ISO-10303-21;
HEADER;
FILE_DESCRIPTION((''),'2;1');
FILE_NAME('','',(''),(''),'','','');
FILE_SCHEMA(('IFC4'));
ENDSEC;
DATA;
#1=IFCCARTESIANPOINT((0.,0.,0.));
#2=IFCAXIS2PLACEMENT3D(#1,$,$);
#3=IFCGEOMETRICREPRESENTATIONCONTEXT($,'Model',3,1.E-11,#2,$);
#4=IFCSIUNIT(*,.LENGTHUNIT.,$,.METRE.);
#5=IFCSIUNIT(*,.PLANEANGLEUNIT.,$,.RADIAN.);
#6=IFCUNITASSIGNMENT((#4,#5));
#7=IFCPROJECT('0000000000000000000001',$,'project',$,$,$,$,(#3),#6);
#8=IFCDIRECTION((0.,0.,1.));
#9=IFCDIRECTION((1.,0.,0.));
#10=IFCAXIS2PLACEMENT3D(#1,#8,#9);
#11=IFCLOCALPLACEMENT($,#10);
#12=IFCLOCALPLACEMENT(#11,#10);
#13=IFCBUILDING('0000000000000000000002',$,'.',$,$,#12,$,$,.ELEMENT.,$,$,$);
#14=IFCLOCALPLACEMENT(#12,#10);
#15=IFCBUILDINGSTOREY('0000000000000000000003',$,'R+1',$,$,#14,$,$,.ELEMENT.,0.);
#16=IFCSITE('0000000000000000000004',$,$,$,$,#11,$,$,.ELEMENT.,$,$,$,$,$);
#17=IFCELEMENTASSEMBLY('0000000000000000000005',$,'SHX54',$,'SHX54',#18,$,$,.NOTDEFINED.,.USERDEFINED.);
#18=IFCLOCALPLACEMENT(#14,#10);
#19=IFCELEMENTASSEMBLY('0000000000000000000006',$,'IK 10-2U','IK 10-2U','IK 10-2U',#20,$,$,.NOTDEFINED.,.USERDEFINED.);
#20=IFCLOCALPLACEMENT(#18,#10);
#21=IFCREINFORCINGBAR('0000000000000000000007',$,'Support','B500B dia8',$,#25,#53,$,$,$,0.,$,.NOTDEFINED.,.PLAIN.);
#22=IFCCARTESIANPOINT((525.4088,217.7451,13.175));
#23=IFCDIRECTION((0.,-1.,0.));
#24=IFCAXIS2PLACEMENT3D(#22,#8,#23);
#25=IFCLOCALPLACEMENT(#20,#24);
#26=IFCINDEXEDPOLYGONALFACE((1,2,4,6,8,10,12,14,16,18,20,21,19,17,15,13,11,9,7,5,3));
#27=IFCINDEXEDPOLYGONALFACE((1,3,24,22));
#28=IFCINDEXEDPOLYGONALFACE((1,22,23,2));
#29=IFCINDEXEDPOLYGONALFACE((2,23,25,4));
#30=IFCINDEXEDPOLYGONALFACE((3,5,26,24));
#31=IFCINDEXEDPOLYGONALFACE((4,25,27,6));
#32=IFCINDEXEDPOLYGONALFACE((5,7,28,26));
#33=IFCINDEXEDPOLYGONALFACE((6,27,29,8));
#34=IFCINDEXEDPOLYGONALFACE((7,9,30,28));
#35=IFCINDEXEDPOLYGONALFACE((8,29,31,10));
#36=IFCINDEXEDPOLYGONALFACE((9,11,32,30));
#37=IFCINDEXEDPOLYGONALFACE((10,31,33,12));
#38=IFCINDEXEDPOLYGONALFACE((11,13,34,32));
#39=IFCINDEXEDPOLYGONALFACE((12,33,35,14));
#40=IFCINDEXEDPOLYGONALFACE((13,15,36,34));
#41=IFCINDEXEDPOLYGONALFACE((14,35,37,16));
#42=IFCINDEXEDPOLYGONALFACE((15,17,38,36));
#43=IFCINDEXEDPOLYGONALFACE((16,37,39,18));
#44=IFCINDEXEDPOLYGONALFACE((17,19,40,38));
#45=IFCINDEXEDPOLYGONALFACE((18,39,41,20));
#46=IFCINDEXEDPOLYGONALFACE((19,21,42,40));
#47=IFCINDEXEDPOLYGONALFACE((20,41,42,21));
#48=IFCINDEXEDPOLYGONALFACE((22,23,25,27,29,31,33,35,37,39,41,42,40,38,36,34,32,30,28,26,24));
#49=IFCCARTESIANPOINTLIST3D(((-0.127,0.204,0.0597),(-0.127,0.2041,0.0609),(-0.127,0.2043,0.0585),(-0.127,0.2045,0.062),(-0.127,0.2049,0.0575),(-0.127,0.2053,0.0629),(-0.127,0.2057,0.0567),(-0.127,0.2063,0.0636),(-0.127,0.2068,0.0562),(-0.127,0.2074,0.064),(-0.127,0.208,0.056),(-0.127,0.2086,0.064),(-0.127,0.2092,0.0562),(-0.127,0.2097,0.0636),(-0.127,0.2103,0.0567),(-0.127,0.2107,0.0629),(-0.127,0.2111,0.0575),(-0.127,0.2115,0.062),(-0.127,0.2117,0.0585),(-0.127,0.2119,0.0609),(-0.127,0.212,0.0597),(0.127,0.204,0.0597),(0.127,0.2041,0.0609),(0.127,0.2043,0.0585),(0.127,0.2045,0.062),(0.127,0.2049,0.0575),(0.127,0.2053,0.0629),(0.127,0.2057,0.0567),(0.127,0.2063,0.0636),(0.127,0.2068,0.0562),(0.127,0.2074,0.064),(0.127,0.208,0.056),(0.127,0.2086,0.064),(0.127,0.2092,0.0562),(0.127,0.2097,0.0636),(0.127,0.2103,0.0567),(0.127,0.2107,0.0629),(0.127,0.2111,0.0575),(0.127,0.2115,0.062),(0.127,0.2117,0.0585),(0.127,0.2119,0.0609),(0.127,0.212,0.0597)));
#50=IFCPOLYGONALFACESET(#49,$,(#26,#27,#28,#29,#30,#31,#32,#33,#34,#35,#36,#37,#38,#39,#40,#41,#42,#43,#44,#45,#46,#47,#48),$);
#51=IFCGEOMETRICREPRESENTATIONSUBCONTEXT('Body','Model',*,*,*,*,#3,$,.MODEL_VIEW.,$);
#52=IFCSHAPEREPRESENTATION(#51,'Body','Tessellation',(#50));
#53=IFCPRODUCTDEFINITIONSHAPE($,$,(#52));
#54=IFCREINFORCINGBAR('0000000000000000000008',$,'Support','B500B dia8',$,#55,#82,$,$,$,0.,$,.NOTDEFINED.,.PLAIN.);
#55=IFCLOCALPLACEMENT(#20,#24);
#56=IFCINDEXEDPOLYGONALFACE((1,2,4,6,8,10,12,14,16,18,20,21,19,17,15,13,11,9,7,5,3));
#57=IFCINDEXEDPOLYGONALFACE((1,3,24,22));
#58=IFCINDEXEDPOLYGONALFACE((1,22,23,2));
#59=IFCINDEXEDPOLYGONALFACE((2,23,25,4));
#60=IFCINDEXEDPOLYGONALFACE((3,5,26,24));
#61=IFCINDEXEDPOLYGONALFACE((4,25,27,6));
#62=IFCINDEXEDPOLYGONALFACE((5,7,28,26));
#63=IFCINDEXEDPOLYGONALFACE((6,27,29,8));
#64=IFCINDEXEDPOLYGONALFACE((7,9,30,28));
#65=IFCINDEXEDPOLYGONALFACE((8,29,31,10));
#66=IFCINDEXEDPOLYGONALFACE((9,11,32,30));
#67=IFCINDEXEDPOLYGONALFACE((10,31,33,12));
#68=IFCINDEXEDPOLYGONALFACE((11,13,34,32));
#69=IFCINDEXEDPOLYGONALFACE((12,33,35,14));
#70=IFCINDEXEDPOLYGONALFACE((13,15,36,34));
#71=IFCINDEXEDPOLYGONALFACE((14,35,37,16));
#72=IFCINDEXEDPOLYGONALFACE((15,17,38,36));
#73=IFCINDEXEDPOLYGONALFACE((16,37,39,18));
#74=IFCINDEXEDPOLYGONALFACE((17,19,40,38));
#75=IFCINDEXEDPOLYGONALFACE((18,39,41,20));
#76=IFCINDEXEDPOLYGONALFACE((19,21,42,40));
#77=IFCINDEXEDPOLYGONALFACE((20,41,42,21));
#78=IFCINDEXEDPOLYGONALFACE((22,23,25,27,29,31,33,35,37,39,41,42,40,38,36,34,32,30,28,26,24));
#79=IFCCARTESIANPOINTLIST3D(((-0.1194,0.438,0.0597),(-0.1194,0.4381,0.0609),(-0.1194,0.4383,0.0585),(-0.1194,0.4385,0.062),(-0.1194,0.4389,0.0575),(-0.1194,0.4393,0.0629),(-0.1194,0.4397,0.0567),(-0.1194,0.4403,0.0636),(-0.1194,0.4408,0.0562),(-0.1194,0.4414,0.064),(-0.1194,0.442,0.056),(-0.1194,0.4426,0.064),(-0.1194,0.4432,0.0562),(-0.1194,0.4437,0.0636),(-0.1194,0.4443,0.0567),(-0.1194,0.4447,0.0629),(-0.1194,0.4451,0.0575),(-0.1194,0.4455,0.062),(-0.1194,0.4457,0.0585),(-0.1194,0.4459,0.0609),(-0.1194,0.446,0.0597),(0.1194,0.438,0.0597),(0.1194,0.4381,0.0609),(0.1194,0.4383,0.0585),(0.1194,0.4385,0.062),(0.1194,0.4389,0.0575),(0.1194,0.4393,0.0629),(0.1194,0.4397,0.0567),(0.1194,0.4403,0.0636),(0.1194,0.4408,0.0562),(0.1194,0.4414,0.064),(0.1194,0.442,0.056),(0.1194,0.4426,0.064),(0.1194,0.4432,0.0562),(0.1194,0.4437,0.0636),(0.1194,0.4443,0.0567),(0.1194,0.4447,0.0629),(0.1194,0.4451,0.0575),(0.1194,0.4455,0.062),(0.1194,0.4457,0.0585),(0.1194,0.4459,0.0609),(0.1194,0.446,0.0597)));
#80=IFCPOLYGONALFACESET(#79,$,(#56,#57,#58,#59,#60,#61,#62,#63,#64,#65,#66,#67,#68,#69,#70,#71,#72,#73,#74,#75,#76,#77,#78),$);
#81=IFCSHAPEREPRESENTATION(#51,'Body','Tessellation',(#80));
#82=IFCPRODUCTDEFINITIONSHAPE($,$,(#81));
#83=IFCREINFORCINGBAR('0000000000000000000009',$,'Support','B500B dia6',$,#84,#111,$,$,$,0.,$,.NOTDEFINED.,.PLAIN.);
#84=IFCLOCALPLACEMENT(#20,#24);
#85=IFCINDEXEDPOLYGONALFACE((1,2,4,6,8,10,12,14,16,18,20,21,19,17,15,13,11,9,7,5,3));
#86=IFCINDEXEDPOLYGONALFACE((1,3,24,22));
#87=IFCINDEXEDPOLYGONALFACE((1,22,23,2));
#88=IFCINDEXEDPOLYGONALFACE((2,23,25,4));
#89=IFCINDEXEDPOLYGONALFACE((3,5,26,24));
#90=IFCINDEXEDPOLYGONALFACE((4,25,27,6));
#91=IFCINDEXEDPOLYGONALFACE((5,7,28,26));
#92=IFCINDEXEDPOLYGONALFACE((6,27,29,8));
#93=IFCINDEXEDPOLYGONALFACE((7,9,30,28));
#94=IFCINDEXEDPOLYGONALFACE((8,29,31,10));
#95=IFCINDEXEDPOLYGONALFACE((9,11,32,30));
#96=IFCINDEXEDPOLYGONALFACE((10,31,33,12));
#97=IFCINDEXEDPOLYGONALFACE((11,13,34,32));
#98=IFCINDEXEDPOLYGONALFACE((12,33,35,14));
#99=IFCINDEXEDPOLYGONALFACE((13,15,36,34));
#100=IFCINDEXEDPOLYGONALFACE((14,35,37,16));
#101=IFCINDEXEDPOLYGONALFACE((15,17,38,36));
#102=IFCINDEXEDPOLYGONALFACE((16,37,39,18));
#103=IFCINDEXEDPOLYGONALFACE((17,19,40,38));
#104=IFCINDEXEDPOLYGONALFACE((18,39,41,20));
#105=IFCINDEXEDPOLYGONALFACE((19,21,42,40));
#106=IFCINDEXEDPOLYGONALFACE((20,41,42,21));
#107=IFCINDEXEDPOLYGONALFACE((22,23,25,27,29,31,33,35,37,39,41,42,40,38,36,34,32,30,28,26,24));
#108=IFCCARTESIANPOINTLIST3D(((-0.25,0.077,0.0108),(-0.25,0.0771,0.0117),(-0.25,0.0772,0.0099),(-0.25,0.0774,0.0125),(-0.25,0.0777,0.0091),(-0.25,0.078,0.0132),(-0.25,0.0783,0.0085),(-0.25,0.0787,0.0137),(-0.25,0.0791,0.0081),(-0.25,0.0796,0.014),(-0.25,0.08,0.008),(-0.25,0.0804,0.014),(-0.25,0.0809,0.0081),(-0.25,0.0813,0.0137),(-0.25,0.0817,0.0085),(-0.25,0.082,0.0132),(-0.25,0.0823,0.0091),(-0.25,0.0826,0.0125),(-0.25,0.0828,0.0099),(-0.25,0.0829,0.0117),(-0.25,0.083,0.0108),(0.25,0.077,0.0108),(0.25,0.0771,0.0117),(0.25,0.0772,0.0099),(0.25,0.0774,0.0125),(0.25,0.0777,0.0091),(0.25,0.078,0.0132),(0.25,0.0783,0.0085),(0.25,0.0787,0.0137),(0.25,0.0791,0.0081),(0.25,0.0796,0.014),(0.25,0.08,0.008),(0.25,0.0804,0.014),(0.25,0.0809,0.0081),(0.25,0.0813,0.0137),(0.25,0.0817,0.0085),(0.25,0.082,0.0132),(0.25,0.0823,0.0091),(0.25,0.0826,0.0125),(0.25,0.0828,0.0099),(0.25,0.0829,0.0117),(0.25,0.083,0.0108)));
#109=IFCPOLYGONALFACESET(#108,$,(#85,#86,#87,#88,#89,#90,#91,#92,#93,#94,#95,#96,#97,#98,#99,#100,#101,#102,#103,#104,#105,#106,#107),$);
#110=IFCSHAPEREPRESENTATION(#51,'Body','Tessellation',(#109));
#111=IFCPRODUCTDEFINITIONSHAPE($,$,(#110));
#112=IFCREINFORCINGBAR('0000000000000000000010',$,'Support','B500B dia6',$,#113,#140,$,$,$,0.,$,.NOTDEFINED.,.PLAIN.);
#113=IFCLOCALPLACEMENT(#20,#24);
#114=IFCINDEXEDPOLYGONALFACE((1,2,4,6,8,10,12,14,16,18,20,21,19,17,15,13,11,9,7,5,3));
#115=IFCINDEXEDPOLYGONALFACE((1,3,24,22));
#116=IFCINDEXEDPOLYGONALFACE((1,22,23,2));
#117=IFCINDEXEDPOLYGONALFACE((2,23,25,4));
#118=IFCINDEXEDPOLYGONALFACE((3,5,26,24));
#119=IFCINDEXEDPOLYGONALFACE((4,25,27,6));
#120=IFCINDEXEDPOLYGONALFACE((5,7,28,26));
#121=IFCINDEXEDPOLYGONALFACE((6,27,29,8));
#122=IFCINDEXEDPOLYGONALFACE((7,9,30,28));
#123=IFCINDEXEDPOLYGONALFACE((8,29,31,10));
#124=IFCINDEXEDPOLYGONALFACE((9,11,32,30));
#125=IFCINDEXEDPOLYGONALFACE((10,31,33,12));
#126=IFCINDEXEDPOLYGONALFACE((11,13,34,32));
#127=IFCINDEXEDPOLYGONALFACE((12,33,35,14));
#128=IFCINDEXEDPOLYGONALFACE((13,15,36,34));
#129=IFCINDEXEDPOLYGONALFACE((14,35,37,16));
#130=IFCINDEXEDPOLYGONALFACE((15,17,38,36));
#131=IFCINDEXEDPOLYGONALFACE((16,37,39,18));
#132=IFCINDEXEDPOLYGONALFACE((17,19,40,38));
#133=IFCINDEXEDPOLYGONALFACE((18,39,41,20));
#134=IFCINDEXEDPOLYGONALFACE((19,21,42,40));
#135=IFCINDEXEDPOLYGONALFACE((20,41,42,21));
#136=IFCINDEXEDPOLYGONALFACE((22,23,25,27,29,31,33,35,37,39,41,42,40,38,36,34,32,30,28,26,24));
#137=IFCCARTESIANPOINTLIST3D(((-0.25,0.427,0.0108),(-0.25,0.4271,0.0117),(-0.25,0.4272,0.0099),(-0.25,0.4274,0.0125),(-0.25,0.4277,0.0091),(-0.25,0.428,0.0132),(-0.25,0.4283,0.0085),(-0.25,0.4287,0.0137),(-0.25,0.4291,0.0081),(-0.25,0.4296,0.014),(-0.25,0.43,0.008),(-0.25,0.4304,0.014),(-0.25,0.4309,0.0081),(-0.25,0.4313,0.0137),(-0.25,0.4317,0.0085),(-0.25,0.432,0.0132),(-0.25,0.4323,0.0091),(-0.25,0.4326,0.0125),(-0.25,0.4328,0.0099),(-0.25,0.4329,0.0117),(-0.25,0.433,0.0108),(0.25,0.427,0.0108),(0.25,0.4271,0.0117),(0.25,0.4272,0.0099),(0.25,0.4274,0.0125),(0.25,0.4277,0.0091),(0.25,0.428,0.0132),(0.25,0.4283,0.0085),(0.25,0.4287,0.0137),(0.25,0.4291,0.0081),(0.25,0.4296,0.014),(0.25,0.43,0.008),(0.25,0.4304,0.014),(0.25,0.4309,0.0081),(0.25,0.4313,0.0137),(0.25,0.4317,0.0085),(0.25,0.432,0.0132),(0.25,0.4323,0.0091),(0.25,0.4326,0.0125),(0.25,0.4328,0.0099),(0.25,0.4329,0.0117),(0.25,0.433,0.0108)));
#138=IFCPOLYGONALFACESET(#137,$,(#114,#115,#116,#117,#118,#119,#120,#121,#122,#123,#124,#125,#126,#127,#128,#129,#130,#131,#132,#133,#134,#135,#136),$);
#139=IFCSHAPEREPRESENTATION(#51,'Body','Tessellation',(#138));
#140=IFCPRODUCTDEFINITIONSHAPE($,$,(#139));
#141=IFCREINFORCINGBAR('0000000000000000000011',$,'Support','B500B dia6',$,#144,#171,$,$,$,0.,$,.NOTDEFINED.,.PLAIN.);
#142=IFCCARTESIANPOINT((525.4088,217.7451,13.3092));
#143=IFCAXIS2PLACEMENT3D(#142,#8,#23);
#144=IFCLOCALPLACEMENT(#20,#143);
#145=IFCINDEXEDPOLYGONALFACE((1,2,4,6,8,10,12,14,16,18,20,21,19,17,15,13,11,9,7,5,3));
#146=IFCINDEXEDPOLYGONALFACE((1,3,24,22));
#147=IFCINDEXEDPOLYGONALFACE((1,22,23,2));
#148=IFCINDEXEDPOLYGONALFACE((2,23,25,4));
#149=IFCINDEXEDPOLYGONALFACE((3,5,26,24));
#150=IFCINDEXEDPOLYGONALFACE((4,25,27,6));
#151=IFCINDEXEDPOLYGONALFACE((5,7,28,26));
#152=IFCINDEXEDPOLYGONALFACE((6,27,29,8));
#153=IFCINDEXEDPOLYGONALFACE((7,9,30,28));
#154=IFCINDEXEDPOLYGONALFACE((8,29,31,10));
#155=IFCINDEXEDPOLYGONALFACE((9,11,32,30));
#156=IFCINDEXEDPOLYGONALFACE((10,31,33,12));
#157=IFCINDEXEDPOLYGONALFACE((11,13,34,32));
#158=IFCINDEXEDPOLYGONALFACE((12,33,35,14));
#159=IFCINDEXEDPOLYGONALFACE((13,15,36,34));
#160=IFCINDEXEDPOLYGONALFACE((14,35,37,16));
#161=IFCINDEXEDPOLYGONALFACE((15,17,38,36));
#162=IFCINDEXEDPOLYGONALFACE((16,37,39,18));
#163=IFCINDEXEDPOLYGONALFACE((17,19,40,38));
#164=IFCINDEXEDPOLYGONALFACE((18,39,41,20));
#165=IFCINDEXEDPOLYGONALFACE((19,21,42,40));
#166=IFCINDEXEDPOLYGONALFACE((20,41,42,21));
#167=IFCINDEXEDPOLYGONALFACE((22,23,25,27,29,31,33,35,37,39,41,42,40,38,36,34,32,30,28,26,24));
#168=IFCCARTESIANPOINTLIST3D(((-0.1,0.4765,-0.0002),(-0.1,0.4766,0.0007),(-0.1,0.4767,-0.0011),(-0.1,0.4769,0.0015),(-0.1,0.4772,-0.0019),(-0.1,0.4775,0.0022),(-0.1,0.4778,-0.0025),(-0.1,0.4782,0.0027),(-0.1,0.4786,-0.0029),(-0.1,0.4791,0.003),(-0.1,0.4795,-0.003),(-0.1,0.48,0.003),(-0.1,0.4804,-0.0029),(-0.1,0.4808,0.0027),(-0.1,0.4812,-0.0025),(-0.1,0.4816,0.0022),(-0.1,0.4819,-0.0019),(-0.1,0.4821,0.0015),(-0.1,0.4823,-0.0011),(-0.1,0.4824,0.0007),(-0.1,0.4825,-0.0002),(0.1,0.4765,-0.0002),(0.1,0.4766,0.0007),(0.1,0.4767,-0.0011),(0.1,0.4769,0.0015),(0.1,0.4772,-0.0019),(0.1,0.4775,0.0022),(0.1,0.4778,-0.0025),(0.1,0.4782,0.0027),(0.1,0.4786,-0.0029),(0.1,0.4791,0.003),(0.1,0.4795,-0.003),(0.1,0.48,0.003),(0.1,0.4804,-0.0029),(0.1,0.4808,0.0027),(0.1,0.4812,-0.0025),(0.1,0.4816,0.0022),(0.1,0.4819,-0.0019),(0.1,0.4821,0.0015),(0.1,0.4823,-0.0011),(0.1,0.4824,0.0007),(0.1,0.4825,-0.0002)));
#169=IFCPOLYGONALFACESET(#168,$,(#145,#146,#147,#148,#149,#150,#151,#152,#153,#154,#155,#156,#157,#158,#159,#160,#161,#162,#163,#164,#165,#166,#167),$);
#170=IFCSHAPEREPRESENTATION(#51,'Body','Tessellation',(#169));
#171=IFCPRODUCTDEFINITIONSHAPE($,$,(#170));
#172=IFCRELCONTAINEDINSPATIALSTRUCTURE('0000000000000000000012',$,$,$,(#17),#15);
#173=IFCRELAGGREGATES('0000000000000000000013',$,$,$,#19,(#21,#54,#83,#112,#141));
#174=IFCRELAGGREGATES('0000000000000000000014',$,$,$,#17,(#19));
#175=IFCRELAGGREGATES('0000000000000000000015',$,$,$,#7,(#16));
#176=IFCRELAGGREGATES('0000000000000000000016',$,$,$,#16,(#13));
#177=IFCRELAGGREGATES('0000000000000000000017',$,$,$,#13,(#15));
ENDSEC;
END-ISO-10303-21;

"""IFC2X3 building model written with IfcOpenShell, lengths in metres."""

from ifc_helpers import new_model, entity, si_unit, frame, origin, origin_with_axes, place, context, subcontext, project, spatial, source, transform, mapped, element, aggregate, save


model = new_model("IFC2X3")

# Units and contexts
model_context = context("Model", 3, precision=1e-11, world=origin())
body_context = subcontext(model_context, "Body", "Model", "MODEL_VIEW")
ifc_project = project(units=[si_unit("LENGTHUNIT", "METRE"), si_unit("PLANEANGLEUNIT", "RADIAN")], contexts=[model_context])

# Site, building, storey
site_placement = place(None, origin_with_axes())
site = spatial("IfcSite", under=ifc_project, at=site_placement, CompositionType="ELEMENT")
building_placement = place(site_placement, origin_with_axes())
building = spatial("IfcBuilding", under=site, at=building_placement, Name=".", CompositionType="ELEMENT")
storey_placement = place(building_placement, origin_with_axes())
storey = spatial("IfcBuildingStorey", under=building, at=storey_placement, Name="R+1", CompositionType="ELEMENT", Elevation=0.0)

# Element assemblies, reinforcing bars
assembly_1_placement = place(storey_placement, origin_with_axes())
assembly_1 = element("IfcElementAssembly", 1, at=assembly_1_placement, inside=storey, Name="SHX54", ObjectType="SHX54", AssemblyPlace="NOTDEFINED", PredefinedType="USERDEFINED")
assembly_2_placement = place(assembly_1_placement, origin_with_axes())
assembly_2 = element("IfcElementAssembly", 2, at=assembly_2_placement, Name="IK 10-2U", Description="IK 10-2U", ObjectType="IK 10-2U", AssemblyPlace="NOTDEFINED", PredefinedType="USERDEFINED")
shared_shape_1 = source(origin_with_axes(), body_context, "Body", "AdvancedSweptSolid", [
    entity("IfcSweptDiskSolid", entity("IfcPolyline", [entity("IfcCartesianPoint", [0.127, 0.208, 0.06]), entity("IfcCartesianPoint", [-0.127, 0.208, 0.06])]), 0.004, None, 0.0, 0.254),
])
reinforcing_bar_1_placement = place(assembly_2_placement, frame((525.4088, 217.7451, 13.175), z_axis=(0.0, 0.0, 1.0), x_axis=(0.0, -1.0, 0.0)))
reinforcing_bar_1 = element("IfcReinforcingBar", 3, at=reinforcing_bar_1_placement, Name="Support", Description="B500B dia8", BarRole="NOTDEFINED", BarSurface="PLAIN", CrossSectionArea=0.0, context=body_context, shape_type="MappedRepresentation", body=[
    mapped(shared_shape_1, transform((0.0, 0.0, 0.0), scale=1.0)),
])
shared_shape_2 = source(origin_with_axes(), body_context, "Body", "AdvancedSweptSolid", [
    entity("IfcSweptDiskSolid", entity("IfcPolyline", [entity("IfcCartesianPoint", [0.1194, 0.442, 0.06]), entity("IfcCartesianPoint", [-0.1194, 0.442, 0.06])]), 0.004, None, 0.0, 0.2388),
])
reinforcing_bar_2_placement = place(assembly_2_placement, frame((525.4088, 217.7451, 13.175), z_axis=(0.0, 0.0, 1.0), x_axis=(0.0, -1.0, 0.0)))
reinforcing_bar_2 = element("IfcReinforcingBar", 4, at=reinforcing_bar_2_placement, Name="Support", Description="B500B dia8", BarRole="NOTDEFINED", BarSurface="PLAIN", CrossSectionArea=0.0, context=body_context, shape_type="MappedRepresentation", body=[
    mapped(shared_shape_2, transform((0.0, 0.0, 0.0), scale=1.0)),
])
shared_shape_3 = source(origin_with_axes(), body_context, "Body", "AdvancedSweptSolid", [
    entity("IfcSweptDiskSolid", entity("IfcPolyline", [entity("IfcCartesianPoint", [0.25, 0.08, 0.011]), entity("IfcCartesianPoint", [-0.25, 0.08, 0.011])]), 0.003, None, 0.0, 0.5),
])
reinforcing_bar_3_placement = place(assembly_2_placement, frame((525.4088, 217.7451, 13.175), z_axis=(0.0, 0.0, 1.0), x_axis=(0.0, -1.0, 0.0)))
reinforcing_bar_3 = element("IfcReinforcingBar", 5, at=reinforcing_bar_3_placement, Name="Support", Description="B500B dia6", BarRole="NOTDEFINED", BarSurface="PLAIN", CrossSectionArea=0.0, context=body_context, shape_type="MappedRepresentation", body=[
    mapped(shared_shape_3, transform((0.0, 0.0, 0.0), scale=1.0)),
])
shared_shape_4 = source(origin_with_axes(), body_context, "Body", "AdvancedSweptSolid", [
    entity("IfcSweptDiskSolid", entity("IfcPolyline", [entity("IfcCartesianPoint", [0.25, 0.43, 0.011]), entity("IfcCartesianPoint", [-0.25, 0.43, 0.011])]), 0.003, None, 0.0, 0.5),
])
reinforcing_bar_4_placement = place(assembly_2_placement, frame((525.4088, 217.7451, 13.175), z_axis=(0.0, 0.0, 1.0), x_axis=(0.0, -1.0, 0.0)))
reinforcing_bar_4 = element("IfcReinforcingBar", 6, at=reinforcing_bar_4_placement, Name="Support", Description="B500B dia6", BarRole="NOTDEFINED", BarSurface="PLAIN", CrossSectionArea=0.0, context=body_context, shape_type="MappedRepresentation", body=[
    mapped(shared_shape_4, transform((0.0, 0.0, 0.0), scale=1.0)),
])
shared_shape_5 = source(origin_with_axes(), body_context, "Body", "AdvancedSweptSolid", [
    entity("IfcSweptDiskSolid", entity("IfcPolyline", [entity("IfcCartesianPoint", [0.1, 0.4795, 0.0]), entity("IfcCartesianPoint", [-0.1, 0.4795, 0.0])]), 0.003, None, 0.0, 0.2),
])
reinforcing_bar_5_placement = place(assembly_2_placement, frame((525.4088, 217.7451, 13.3092), z_axis=(0.0, 0.0, 1.0), x_axis=(0.0, -1.0, 0.0)))
reinforcing_bar_5 = element("IfcReinforcingBar", 7, at=reinforcing_bar_5_placement, Name="Support", Description="B500B dia6", BarRole="NOTDEFINED", BarSurface="PLAIN", CrossSectionArea=0.0, context=body_context, shape_type="MappedRepresentation", body=[
    mapped(shared_shape_5, transform((0.0, 0.0, 0.0), scale=1.0)),
])
aggregate(assembly_2, [reinforcing_bar_1, reinforcing_bar_2, reinforcing_bar_3, reinforcing_bar_4, reinforcing_bar_5])

aggregate(assembly_1, [assembly_2])

save(model, "model.ifc")
